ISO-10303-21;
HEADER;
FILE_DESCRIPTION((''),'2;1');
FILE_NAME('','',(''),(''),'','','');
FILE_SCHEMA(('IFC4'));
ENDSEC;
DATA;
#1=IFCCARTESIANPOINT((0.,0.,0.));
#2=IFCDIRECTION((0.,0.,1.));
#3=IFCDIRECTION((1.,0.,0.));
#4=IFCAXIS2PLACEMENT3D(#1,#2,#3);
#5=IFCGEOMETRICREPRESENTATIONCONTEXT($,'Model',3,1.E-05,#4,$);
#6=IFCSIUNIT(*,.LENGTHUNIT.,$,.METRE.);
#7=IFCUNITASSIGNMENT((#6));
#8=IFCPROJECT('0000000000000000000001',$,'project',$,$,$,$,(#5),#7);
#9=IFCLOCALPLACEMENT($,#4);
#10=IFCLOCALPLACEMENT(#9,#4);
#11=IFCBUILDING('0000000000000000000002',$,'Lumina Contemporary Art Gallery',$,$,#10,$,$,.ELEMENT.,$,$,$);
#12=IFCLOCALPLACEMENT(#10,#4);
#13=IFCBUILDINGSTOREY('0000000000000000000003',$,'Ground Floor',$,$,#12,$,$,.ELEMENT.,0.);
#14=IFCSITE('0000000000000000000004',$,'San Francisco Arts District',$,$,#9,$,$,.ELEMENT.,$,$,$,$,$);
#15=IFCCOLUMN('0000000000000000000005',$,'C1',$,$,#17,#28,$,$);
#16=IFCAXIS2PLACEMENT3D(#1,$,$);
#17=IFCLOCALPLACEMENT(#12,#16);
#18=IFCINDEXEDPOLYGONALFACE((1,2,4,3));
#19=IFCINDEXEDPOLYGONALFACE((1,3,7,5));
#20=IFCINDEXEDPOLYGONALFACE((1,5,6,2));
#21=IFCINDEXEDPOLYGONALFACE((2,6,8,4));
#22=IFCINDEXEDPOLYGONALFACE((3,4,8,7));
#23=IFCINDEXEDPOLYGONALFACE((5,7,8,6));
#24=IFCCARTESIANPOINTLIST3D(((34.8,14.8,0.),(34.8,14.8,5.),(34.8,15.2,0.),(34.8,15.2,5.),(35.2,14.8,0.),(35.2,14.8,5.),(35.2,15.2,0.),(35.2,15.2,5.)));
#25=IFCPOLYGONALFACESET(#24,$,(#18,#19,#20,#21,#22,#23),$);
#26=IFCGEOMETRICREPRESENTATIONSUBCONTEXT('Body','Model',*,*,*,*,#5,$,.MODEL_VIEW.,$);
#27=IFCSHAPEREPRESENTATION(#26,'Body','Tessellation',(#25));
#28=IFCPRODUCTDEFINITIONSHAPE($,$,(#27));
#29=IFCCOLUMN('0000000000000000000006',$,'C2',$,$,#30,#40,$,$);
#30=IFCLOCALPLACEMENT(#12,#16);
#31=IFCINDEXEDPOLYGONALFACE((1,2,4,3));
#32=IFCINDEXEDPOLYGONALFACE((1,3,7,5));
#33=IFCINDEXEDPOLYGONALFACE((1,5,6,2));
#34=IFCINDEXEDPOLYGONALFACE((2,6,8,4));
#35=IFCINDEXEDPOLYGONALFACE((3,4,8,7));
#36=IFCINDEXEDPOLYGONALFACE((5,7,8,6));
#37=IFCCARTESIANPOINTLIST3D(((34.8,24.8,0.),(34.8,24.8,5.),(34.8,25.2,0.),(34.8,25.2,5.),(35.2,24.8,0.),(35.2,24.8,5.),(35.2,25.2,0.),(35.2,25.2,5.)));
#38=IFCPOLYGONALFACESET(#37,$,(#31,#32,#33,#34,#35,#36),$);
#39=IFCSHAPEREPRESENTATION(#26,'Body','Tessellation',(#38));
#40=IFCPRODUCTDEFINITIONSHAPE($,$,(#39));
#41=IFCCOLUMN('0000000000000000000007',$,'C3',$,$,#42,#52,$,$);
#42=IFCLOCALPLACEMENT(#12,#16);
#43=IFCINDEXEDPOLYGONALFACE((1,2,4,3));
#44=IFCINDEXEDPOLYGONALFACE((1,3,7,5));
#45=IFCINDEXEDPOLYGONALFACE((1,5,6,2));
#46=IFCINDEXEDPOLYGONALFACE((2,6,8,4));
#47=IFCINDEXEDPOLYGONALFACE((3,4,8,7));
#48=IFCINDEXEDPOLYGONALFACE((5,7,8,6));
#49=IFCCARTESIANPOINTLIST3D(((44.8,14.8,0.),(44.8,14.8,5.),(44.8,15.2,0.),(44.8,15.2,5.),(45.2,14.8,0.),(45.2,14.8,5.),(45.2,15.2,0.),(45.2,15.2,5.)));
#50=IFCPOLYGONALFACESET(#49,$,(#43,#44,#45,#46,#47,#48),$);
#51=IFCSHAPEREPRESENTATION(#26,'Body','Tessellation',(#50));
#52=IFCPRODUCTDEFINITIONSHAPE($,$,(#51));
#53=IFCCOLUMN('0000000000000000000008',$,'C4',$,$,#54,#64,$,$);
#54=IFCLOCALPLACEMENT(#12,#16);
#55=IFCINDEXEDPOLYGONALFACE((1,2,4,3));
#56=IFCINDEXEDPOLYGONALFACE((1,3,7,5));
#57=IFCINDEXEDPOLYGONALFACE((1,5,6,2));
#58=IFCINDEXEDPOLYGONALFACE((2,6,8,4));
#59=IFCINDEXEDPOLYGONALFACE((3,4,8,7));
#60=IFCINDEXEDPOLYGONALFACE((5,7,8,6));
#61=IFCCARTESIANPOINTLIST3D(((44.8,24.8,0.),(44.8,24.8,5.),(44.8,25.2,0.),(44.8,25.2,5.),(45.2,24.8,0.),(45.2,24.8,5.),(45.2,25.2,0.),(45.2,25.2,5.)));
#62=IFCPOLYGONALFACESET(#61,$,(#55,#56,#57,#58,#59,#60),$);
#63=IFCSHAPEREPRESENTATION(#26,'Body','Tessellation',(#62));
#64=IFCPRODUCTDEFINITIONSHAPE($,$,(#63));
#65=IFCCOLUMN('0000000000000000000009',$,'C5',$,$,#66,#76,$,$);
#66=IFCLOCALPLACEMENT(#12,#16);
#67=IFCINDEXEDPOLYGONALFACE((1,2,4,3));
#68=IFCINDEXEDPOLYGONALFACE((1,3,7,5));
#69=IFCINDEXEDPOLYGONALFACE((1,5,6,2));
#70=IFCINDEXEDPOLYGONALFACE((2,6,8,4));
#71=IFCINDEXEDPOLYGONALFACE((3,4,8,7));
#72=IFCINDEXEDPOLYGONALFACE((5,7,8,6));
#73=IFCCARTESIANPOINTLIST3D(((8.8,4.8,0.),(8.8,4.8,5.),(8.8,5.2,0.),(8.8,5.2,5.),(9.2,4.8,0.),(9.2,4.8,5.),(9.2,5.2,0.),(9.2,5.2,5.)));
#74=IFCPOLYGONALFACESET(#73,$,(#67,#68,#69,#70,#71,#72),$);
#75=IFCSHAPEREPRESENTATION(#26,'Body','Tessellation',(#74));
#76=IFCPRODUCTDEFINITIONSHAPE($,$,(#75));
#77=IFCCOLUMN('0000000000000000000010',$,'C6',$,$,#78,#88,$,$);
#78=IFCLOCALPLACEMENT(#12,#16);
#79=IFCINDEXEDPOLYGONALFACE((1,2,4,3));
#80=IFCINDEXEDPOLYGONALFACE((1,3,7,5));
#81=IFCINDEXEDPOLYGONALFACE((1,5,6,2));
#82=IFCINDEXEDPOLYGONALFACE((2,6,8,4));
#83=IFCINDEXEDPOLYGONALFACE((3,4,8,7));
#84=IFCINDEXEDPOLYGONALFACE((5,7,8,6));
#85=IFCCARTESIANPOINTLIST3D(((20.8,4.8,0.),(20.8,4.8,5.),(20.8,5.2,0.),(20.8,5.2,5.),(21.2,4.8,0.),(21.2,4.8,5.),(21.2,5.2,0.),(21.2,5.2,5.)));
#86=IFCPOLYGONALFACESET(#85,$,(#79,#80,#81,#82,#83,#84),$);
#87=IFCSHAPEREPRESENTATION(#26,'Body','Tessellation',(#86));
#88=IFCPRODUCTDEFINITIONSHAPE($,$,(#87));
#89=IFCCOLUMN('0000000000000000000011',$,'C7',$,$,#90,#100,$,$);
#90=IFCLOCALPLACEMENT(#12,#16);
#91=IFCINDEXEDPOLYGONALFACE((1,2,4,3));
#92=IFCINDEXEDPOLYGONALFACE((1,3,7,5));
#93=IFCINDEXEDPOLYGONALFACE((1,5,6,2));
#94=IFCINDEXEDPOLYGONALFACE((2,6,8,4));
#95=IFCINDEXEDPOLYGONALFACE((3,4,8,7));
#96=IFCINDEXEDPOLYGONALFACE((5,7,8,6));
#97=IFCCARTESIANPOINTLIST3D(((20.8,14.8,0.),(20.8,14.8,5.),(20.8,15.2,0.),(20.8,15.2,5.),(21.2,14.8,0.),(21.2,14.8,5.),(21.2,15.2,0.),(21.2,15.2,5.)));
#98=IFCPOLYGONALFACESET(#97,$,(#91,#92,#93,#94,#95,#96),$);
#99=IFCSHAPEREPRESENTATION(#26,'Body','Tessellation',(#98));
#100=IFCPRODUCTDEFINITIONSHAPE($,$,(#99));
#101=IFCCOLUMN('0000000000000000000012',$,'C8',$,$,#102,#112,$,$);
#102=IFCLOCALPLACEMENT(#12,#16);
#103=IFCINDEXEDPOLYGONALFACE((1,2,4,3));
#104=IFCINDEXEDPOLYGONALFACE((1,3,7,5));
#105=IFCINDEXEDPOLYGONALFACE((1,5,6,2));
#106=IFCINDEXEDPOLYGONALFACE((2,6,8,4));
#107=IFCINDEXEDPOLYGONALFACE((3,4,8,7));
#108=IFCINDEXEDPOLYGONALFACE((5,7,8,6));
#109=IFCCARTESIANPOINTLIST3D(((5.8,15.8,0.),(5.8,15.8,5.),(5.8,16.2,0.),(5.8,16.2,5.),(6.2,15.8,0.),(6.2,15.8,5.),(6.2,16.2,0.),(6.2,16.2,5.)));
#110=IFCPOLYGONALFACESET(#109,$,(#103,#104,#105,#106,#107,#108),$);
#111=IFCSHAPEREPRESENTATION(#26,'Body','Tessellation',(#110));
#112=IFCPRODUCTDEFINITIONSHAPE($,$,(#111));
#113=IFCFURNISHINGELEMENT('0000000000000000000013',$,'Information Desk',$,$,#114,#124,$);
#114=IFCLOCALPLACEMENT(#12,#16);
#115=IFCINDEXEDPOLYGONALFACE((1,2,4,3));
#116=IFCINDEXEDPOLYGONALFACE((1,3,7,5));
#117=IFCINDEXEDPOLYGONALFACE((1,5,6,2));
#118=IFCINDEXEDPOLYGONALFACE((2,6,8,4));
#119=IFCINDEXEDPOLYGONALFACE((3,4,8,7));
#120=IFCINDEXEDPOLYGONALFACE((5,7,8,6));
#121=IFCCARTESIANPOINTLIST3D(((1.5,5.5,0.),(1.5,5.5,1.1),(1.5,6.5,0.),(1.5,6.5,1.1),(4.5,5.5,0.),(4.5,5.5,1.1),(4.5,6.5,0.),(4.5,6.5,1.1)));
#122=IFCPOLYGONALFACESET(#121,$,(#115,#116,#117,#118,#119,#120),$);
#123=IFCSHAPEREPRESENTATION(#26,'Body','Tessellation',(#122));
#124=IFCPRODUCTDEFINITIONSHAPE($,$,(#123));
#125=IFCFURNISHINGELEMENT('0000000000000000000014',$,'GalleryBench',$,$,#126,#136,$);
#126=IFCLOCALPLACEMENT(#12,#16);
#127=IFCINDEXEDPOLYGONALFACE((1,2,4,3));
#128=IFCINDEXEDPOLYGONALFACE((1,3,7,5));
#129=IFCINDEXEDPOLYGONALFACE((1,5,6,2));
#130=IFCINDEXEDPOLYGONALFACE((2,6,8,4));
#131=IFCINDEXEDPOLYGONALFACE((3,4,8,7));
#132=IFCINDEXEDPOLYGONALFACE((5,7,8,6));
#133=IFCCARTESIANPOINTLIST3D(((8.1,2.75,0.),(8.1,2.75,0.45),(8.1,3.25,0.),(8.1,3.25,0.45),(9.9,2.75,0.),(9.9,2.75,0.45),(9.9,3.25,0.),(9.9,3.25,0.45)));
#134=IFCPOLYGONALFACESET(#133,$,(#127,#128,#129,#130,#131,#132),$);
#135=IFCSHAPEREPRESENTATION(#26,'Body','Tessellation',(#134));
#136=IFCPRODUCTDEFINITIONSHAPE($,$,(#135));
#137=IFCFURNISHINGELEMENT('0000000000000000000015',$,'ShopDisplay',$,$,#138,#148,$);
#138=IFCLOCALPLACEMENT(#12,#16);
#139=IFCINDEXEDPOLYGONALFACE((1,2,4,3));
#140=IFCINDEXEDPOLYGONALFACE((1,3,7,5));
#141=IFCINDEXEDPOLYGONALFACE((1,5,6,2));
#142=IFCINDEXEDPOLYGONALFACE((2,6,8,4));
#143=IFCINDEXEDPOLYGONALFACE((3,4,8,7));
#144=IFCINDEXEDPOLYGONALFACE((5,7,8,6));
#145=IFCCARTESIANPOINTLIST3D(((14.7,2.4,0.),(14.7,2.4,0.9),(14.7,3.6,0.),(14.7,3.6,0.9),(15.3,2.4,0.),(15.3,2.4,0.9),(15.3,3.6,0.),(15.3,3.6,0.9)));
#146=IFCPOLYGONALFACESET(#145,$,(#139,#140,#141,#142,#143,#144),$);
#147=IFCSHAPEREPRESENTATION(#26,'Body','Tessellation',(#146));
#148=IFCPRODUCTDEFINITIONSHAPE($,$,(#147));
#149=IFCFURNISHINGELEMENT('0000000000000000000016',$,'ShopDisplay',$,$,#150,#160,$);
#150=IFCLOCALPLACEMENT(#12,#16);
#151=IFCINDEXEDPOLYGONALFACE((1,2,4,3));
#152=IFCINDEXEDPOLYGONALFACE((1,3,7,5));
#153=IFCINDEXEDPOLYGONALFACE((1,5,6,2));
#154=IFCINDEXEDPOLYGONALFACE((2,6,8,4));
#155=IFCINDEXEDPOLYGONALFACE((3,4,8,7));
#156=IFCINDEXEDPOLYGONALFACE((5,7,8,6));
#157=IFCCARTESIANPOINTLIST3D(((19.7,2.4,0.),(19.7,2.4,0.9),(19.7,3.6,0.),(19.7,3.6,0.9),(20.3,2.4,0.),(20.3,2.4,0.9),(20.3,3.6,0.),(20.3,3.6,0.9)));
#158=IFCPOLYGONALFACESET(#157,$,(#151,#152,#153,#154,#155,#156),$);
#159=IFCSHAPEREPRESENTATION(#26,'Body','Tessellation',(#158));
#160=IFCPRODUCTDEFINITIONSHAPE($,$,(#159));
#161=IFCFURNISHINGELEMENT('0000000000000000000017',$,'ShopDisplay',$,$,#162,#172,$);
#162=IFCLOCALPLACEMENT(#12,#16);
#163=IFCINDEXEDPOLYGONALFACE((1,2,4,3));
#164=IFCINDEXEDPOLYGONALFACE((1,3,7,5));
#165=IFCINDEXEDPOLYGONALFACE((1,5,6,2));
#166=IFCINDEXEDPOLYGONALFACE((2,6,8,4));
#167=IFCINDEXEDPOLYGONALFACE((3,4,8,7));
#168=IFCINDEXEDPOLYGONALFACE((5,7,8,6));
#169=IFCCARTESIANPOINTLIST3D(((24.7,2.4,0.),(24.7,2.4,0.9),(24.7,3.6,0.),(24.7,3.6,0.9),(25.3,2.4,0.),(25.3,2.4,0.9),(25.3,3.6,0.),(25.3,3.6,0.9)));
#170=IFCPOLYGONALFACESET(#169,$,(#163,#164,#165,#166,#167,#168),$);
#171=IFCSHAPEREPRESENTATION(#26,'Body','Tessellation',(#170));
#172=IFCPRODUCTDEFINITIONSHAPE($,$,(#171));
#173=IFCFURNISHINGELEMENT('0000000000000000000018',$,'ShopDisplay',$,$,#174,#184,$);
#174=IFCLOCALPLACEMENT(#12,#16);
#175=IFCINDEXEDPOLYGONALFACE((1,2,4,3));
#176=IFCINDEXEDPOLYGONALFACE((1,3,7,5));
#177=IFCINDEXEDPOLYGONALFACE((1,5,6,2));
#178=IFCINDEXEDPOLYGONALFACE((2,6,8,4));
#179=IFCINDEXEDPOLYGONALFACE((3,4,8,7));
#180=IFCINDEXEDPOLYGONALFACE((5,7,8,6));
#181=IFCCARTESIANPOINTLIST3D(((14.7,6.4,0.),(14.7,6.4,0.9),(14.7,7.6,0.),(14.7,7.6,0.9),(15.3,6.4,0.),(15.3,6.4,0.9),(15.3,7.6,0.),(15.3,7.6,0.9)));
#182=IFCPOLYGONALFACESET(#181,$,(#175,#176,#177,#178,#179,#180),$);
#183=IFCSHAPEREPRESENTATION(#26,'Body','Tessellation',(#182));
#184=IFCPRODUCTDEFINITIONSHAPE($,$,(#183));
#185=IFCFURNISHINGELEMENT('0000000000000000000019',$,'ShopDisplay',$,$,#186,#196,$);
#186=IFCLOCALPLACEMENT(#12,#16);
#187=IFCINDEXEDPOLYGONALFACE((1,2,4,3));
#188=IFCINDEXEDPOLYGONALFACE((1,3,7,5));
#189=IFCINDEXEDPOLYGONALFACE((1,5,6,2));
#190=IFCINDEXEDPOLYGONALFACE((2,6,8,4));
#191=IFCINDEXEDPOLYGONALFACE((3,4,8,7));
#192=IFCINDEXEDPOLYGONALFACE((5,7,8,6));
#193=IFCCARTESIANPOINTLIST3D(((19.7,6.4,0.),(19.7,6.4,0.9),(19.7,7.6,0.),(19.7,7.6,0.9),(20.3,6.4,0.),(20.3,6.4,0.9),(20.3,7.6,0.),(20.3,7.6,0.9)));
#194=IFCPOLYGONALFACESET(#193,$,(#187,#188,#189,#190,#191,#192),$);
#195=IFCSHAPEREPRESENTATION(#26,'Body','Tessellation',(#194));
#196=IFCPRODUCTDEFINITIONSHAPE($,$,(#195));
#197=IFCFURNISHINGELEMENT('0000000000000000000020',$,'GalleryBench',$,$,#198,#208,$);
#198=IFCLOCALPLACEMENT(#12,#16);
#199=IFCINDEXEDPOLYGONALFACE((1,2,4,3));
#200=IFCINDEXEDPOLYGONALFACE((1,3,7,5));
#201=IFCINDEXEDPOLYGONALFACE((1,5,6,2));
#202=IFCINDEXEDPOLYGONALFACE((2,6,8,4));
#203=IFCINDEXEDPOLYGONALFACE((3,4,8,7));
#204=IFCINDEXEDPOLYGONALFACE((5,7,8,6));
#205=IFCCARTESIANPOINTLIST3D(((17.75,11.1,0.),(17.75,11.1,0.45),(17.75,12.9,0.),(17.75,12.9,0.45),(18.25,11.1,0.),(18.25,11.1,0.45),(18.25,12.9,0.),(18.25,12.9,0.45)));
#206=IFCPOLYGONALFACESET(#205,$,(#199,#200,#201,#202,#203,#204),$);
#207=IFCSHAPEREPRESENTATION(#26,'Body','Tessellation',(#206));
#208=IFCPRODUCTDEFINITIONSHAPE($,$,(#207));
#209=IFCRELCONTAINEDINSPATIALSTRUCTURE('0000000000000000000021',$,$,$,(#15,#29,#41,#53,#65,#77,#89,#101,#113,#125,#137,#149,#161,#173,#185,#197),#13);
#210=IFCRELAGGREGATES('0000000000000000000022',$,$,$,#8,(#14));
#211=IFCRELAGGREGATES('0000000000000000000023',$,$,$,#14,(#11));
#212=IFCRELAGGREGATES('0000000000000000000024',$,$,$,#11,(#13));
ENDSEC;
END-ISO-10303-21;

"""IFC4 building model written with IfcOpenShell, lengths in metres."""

from ifc_helpers import new_model, si_unit, origin_with_axes, place, context, subcontext, project, spatial, polyline, outline, extrude, element, save


model = new_model("IFC4")

# Units and contexts
model_context = context("Model", 3, precision=1e-05, world=origin_with_axes())
body_context = subcontext(model_context, "Body", "Model", "MODEL_VIEW")
ifc_project = project(units=[si_unit("LENGTHUNIT", "METRE")], contexts=[model_context])

# Site, building, storey
site_placement = place(None, origin_with_axes())
site = spatial("IfcSite", under=ifc_project, at=site_placement, Name="San Francisco Arts District", CompositionType="ELEMENT")
building_placement = place(site_placement, origin_with_axes())
building = spatial("IfcBuilding", under=site, at=building_placement, Name="Lumina Contemporary Art Gallery", CompositionType="ELEMENT")
storey_placement = place(building_placement, origin_with_axes())
storey = spatial("IfcBuildingStorey", under=building, at=storey_placement, Name="Ground Floor", CompositionType="ELEMENT", Elevation=0.0)

# Columns
column_1_placement = place(storey_placement, origin_with_axes())
element("IfcColumn", 1, at=column_1_placement, inside=storey, Name="C1", context=body_context, shape_type="SweptSolid", body=[
    extrude(outline(polyline([(34.8, 14.8, 0.0), (35.2, 14.8, 0.0), (35.2, 15.2, 0.0), (34.8, 15.2, 0.0), (34.8, 14.8, 0.0)])), None, (0.0, 0.0, 1.0), 5.0),
])
column_2_placement = place(storey_placement, origin_with_axes())
element("IfcColumn", 2, at=column_2_placement, inside=storey, Name="C2", context=body_context, shape_type="SweptSolid", body=[
    extrude(outline(polyline([(34.8, 24.8, 0.0), (35.2, 24.8, 0.0), (35.2, 25.2, 0.0), (34.8, 25.2, 0.0), (34.8, 24.8, 0.0)])), None, (0.0, 0.0, 1.0), 5.0),
])
column_3_placement = place(storey_placement, origin_with_axes())
element("IfcColumn", 3, at=column_3_placement, inside=storey, Name="C3", context=body_context, shape_type="SweptSolid", body=[
    extrude(outline(polyline([(44.8, 14.8, 0.0), (45.2, 14.8, 0.0), (45.2, 15.2, 0.0), (44.8, 15.2, 0.0), (44.8, 14.8, 0.0)])), None, (0.0, 0.0, 1.0), 5.0),
])
column_4_placement = place(storey_placement, origin_with_axes())
element("IfcColumn", 4, at=column_4_placement, inside=storey, Name="C4", context=body_context, shape_type="SweptSolid", body=[
    extrude(outline(polyline([(44.8, 24.8, 0.0), (45.2, 24.8, 0.0), (45.2, 25.2, 0.0), (44.8, 25.2, 0.0), (44.8, 24.8, 0.0)])), None, (0.0, 0.0, 1.0), 5.0),
])
column_5_placement = place(storey_placement, origin_with_axes())
element("IfcColumn", 5, at=column_5_placement, inside=storey, Name="C5", context=body_context, shape_type="SweptSolid", body=[
    extrude(outline(polyline([(8.8, 4.8, 0.0), (9.2, 4.8, 0.0), (9.2, 5.2, 0.0), (8.8, 5.2, 0.0), (8.8, 4.8, 0.0)])), None, (0.0, 0.0, 1.0), 5.0),
])
column_6_placement = place(storey_placement, origin_with_axes())
element("IfcColumn", 6, at=column_6_placement, inside=storey, Name="C6", context=body_context, shape_type="SweptSolid", body=[
    extrude(outline(polyline([(20.8, 4.8, 0.0), (21.2, 4.8, 0.0), (21.2, 5.2, 0.0), (20.8, 5.2, 0.0), (20.8, 4.8, 0.0)])), None, (0.0, 0.0, 1.0), 5.0),
])
column_7_placement = place(storey_placement, origin_with_axes())
element("IfcColumn", 7, at=column_7_placement, inside=storey, Name="C7", context=body_context, shape_type="SweptSolid", body=[
    extrude(outline(polyline([(20.8, 14.8, 0.0), (21.2, 14.8, 0.0), (21.2, 15.2, 0.0), (20.8, 15.2, 0.0), (20.8, 14.8, 0.0)])), None, (0.0, 0.0, 1.0), 5.0),
])
column_8_placement = place(storey_placement, origin_with_axes())
element("IfcColumn", 8, at=column_8_placement, inside=storey, Name="C8", context=body_context, shape_type="SweptSolid", body=[
    extrude(outline(polyline([(5.8, 15.8, 0.0), (6.2, 15.8, 0.0), (6.2, 16.2, 0.0), (5.8, 16.2, 0.0), (5.8, 15.8, 0.0)])), None, (0.0, 0.0, 1.0), 5.0),
])

# Furnishing elements
furnishing_1_placement = place(storey_placement, origin_with_axes())
element("IfcFurnishingElement", 9, at=furnishing_1_placement, inside=storey, Name="Information Desk", context=body_context, shape_type="SweptSolid", body=[
    extrude(outline(polyline([(4.5, 6.5, 0.0), (1.5, 6.5, 0.0), (1.5, 5.5, 0.0), (4.5, 5.5, 0.0), (4.5, 6.5, 0.0)])), None, (0.0, 0.0, 1.0), 1.1),
])
furnishing_2_placement = place(storey_placement, origin_with_axes())
element("IfcFurnishingElement", 10, at=furnishing_2_placement, inside=storey, Name="GalleryBench", context=body_context, shape_type="SweptSolid", body=[
    extrude(outline(polyline([(8.1, 2.75, 0.0), (9.9, 2.75, 0.0), (9.9, 3.25, 0.0), (8.1, 3.25, 0.0), (8.1, 2.75, 0.0)])), None, (0.0, 0.0, 1.0), 0.45),
])
furnishing_3_placement = place(storey_placement, origin_with_axes())
element("IfcFurnishingElement", 11, at=furnishing_3_placement, inside=storey, Name="ShopDisplay", context=body_context, shape_type="SweptSolid", body=[
    extrude(outline(polyline([(15.3, 2.4, 0.0), (15.3, 3.6, 0.0), (14.7, 3.6, 0.0), (14.7, 2.4, 0.0), (15.3, 2.4, 0.0)])), None, (0.0, 0.0, 1.0), 0.9),
])
furnishing_4_placement = place(storey_placement, origin_with_axes())
element("IfcFurnishingElement", 12, at=furnishing_4_placement, inside=storey, Name="ShopDisplay", context=body_context, shape_type="SweptSolid", body=[
    extrude(outline(polyline([(20.3, 2.4, 0.0), (20.3, 3.6, 0.0), (19.7, 3.6, 0.0), (19.7, 2.4, 0.0), (20.3, 2.4, 0.0)])), None, (0.0, 0.0, 1.0), 0.9),
])
furnishing_5_placement = place(storey_placement, origin_with_axes())
element("IfcFurnishingElement", 13, at=furnishing_5_placement, inside=storey, Name="ShopDisplay", context=body_context, shape_type="SweptSolid", body=[
    extrude(outline(polyline([(25.3, 2.4, 0.0), (25.3, 3.6, 0.0), (24.7, 3.6, 0.0), (24.7, 2.4, 0.0), (25.3, 2.4, 0.0)])), None, (0.0, 0.0, 1.0), 0.9),
])
furnishing_6_placement = place(storey_placement, origin_with_axes())
element("IfcFurnishingElement", 14, at=furnishing_6_placement, inside=storey, Name="ShopDisplay", context=body_context, shape_type="SweptSolid", body=[
    extrude(outline(polyline([(14.7, 7.6, 0.0), (14.7, 6.4, 0.0), (15.3, 6.4, 0.0), (15.3, 7.6, 0.0), (14.7, 7.6, 0.0)])), None, (0.0, 0.0, 1.0), 0.9),
])
furnishing_7_placement = place(storey_placement, origin_with_axes())
element("IfcFurnishingElement", 15, at=furnishing_7_placement, inside=storey, Name="ShopDisplay", context=body_context, shape_type="SweptSolid", body=[
    extrude(outline(polyline([(19.7, 7.6, 0.0), (19.7, 6.4, 0.0), (20.3, 6.4, 0.0), (20.3, 7.6, 0.0), (19.7, 7.6, 0.0)])), None, (0.0, 0.0, 1.0), 0.9),
])
furnishing_8_placement = place(storey_placement, origin_with_axes())
element("IfcFurnishingElement", 16, at=furnishing_8_placement, inside=storey, Name="GalleryBench", context=body_context, shape_type="SweptSolid", body=[
    extrude(outline(polyline([(17.75, 12.9, 0.0), (17.75, 11.1, 0.0), (18.25, 11.1, 0.0), (18.25, 12.9, 0.0), (17.75, 12.9, 0.0)])), None, (0.0, 0.0, 1.0), 0.45),
])

save(model, "model.ifc")
